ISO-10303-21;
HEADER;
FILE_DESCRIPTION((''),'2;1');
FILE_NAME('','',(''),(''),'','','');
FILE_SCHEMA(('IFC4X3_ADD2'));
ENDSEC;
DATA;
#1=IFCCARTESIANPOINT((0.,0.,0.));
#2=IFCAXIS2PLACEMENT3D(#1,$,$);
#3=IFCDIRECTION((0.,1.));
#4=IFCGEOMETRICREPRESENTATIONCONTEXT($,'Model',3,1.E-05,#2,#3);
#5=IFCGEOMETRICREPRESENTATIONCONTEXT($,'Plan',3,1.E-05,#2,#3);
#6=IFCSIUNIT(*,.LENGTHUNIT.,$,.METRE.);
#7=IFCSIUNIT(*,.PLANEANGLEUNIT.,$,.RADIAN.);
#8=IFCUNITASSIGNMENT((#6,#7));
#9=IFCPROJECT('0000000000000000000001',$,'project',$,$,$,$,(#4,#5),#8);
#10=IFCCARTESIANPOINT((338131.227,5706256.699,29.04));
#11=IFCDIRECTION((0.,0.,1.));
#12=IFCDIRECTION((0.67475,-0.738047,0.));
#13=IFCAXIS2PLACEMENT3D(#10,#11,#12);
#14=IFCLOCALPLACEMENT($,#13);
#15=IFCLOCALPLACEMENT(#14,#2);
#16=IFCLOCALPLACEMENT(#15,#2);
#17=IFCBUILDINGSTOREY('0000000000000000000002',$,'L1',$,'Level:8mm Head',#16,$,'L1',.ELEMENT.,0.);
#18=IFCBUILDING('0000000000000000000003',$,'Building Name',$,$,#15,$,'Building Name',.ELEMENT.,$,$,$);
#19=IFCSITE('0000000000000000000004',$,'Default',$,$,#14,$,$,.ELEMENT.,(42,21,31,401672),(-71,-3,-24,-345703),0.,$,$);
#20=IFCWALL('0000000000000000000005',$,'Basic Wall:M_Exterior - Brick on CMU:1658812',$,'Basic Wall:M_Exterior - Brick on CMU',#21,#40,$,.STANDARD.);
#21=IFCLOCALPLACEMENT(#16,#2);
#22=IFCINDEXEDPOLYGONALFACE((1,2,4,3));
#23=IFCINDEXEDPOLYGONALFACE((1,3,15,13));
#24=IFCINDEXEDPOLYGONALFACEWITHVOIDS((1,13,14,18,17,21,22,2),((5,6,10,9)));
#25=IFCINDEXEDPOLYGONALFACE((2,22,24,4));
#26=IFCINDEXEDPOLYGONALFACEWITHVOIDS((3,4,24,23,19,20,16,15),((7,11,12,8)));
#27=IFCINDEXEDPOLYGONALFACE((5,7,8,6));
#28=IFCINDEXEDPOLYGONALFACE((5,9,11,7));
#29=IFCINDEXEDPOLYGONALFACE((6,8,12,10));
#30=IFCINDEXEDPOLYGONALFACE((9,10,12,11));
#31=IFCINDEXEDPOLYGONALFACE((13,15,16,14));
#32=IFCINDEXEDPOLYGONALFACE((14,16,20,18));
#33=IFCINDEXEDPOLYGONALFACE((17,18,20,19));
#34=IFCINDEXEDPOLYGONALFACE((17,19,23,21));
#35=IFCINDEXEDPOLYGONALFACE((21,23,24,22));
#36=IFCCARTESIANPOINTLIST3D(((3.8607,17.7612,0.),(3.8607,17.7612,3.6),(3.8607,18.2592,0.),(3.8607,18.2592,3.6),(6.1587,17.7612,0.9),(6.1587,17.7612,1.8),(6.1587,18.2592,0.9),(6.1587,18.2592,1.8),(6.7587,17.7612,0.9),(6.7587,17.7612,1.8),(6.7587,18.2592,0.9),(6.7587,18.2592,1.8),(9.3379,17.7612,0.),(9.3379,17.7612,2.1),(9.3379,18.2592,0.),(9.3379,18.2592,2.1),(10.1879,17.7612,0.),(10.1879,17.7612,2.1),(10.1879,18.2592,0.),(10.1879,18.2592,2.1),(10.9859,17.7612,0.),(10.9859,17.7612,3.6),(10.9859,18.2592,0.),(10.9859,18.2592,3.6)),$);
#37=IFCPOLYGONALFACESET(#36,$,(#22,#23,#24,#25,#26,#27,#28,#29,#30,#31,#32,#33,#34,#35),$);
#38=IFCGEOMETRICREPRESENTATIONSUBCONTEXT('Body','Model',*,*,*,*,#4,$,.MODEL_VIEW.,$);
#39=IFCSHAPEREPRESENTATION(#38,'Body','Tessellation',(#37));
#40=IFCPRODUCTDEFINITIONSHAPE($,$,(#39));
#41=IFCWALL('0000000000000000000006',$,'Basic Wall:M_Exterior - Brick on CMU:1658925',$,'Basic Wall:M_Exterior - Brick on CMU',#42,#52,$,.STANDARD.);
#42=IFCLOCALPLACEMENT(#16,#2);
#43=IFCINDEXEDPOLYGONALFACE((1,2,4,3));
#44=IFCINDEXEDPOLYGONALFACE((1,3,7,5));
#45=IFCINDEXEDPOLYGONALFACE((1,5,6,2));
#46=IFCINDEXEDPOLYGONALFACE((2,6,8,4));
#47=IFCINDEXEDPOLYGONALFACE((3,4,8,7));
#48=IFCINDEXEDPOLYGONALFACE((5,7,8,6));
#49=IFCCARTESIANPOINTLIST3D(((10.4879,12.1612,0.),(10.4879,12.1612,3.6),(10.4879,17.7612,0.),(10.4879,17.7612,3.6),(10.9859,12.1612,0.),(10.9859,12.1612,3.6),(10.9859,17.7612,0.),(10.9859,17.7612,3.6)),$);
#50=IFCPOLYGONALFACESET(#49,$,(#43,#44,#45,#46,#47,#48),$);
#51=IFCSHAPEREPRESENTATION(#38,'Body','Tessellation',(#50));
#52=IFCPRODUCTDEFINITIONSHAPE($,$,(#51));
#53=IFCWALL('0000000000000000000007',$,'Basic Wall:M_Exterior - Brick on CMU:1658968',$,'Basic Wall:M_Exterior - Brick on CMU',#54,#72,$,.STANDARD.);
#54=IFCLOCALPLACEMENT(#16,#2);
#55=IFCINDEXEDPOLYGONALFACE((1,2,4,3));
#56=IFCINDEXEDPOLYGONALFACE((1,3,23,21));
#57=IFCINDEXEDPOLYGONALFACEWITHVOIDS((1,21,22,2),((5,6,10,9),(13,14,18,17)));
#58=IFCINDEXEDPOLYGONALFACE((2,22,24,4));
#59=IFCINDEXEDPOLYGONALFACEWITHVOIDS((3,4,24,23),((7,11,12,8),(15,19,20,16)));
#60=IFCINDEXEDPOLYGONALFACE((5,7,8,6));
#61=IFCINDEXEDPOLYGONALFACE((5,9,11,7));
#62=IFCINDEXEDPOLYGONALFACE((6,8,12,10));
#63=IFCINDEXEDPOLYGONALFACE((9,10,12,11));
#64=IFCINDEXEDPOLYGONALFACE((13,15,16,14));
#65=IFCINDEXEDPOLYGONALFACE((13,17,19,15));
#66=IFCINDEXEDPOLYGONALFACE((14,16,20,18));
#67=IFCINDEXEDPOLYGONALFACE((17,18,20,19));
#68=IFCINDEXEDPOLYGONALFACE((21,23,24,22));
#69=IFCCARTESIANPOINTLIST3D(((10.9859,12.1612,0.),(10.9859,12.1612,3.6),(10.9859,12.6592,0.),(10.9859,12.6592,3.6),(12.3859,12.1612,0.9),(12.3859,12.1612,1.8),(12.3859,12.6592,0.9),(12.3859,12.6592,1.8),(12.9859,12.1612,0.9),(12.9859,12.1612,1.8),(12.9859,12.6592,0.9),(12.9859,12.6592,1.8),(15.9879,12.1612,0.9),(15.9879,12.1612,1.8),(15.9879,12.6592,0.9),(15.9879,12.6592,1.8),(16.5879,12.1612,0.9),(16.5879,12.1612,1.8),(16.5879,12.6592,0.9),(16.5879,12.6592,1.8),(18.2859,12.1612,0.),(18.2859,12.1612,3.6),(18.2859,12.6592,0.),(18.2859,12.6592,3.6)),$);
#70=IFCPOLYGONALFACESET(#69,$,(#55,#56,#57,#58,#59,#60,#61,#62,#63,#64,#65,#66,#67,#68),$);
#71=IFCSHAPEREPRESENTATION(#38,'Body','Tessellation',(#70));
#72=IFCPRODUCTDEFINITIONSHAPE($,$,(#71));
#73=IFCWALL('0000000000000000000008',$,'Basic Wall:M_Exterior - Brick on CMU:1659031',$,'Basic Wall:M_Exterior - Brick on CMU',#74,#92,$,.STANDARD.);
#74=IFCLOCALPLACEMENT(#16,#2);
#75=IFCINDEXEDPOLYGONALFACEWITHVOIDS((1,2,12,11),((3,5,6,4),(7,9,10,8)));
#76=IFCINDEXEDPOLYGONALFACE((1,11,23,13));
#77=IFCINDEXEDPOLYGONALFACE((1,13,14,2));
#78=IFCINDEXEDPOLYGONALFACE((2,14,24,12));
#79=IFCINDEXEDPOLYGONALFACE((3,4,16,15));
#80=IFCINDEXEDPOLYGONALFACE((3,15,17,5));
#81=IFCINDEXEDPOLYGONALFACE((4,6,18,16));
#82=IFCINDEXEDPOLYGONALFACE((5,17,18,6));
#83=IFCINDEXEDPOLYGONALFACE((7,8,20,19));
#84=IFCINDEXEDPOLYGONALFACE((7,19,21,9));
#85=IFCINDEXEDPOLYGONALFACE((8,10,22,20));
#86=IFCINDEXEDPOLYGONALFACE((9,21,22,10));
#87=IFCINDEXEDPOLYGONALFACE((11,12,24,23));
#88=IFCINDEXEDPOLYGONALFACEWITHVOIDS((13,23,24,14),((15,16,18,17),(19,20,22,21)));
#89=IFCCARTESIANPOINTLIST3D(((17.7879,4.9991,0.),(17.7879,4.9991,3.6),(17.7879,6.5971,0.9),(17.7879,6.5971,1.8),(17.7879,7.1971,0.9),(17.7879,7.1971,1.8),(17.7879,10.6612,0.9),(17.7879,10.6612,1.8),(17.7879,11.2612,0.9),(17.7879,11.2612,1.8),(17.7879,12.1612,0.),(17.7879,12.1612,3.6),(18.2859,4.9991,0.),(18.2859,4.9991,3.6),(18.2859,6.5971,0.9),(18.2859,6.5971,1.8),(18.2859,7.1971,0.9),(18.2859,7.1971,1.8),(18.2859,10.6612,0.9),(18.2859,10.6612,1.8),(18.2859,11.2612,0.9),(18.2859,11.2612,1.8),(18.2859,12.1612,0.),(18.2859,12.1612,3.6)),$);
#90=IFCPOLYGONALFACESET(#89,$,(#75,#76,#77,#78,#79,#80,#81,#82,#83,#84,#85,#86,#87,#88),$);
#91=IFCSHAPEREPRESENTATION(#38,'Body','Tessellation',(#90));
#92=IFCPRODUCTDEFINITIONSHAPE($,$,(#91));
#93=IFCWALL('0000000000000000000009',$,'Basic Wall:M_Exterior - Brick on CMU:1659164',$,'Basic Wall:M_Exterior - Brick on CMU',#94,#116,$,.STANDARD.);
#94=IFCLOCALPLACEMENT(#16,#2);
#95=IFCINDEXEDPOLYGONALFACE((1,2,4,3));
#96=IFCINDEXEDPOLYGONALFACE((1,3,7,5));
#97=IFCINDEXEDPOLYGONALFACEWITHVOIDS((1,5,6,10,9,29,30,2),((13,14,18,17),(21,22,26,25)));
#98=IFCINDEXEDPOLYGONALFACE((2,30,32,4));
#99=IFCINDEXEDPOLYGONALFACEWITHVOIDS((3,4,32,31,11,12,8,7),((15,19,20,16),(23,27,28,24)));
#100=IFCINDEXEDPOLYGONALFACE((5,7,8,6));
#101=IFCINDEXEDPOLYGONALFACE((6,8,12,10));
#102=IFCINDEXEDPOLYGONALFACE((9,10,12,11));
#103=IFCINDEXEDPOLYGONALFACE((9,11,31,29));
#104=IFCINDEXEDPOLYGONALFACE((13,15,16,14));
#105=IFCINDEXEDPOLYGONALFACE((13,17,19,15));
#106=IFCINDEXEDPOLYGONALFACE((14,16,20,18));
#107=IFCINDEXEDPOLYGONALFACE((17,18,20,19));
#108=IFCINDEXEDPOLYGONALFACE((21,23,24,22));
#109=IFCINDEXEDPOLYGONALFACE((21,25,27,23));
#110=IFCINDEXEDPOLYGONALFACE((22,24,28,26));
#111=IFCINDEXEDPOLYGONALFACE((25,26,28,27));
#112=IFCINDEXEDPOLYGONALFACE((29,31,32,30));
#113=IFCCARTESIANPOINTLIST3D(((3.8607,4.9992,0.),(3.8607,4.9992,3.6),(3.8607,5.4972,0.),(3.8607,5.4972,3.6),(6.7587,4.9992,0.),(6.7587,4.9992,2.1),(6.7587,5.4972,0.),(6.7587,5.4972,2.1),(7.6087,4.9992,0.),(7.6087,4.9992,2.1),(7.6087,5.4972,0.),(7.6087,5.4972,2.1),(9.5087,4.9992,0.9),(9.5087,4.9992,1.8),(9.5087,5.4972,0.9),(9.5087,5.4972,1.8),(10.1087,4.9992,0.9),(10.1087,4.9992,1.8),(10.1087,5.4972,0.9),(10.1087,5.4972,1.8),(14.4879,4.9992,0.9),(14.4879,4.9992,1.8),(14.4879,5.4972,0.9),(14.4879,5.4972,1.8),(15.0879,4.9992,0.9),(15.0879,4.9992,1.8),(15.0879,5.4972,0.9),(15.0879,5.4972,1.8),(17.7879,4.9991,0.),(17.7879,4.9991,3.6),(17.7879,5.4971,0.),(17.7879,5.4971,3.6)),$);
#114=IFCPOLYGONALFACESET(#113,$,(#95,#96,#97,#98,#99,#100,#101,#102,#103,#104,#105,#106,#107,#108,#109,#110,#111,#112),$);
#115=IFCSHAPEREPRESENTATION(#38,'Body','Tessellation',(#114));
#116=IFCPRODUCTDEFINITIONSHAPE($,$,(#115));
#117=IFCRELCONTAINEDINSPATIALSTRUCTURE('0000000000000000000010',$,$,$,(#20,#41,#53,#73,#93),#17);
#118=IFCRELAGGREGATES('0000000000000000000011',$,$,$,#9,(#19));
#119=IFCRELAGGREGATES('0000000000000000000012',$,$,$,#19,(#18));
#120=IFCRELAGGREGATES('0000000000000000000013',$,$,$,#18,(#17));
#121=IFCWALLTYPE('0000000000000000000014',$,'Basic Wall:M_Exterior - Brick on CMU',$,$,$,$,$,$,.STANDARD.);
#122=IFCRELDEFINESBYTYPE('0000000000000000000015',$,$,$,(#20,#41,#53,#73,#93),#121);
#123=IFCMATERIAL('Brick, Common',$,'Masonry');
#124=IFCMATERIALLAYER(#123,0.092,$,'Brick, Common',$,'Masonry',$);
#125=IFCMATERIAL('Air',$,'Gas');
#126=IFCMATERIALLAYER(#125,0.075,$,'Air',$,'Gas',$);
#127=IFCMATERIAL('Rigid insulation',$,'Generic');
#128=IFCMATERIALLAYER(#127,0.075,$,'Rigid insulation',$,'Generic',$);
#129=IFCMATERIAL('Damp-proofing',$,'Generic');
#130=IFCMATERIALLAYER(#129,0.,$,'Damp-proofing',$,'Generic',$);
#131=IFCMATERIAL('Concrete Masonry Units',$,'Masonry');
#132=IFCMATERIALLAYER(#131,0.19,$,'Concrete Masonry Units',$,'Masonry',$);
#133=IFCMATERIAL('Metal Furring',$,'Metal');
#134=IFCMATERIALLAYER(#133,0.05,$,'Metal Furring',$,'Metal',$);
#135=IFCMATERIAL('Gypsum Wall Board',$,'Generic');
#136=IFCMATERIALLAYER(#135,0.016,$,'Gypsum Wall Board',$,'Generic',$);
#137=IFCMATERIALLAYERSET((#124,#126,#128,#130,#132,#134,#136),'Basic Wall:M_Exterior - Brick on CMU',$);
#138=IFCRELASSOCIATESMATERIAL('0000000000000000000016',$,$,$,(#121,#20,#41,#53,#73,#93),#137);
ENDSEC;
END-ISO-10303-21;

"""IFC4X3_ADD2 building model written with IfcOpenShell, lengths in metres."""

from ifc_helpers import new_model, si_unit, direction, frame, frame_2d, origin, origin_2d_with_axis, place, context, subcontext, project, spatial, rectangle, extrude, material, layer, layer_set, type_object, element, save


model = new_model("IFC4X3_ADD2")

# Units and contexts
model_context = context("Model", 3, precision=1e-05, world=origin(), true_north=direction((0.0, 1.0)))
plan_context = context("Plan", 3, precision=1e-05, world=origin(), true_north=direction((0.0, 1.0)))
body_context = subcontext(model_context, "Body", "Model", "MODEL_VIEW")
ifc_project = project(units=[si_unit("LENGTHUNIT", "METRE"), si_unit("PLANEANGLEUNIT", "RADIAN")], contexts=[model_context, plan_context])

# Site, building, storey
site_placement = place(None, frame((338131.227, 5706256.699, 29.04), z_axis=(0.0, 0.0, 1.0), x_axis=(0.67475, -0.738047, 0.0)))
site = spatial("IfcSite", under=ifc_project, at=site_placement, Name="Default", CompositionType="ELEMENT", RefLatitude=(42, 21, 31, 401672), RefLongitude=(-71, -3, -24, -345703), RefElevation=0.0)
building_placement = place(site_placement, origin())
building = spatial("IfcBuilding", under=site, at=building_placement, Name="Building Name", LongName="Building Name", CompositionType="ELEMENT")
storey_placement = place(building_placement, origin())
storey = spatial("IfcBuildingStorey", under=building, at=storey_placement, Name="L1", ObjectType="Level:8mm Head", LongName="L1", CompositionType="ELEMENT", Elevation=0.0)

# Wall, openings
ifc_material_1 = material(Name="Brick, Common", Category="Masonry")
ifc_layer_1 = layer(ifc_material_1, 0.092, Name="Brick, Common", Category="Masonry")
ifc_material_2 = material(Name="Air", Category="Gas")
ifc_layer_2 = layer(ifc_material_2, 0.075, Name="Air", Category="Gas")
ifc_material_3 = material(Name="Rigid insulation", Category="Generic")
ifc_layer_3 = layer(ifc_material_3, 0.075, Name="Rigid insulation", Category="Generic")
ifc_material_4 = material(Name="Damp-proofing", Category="Generic")
ifc_layer_4 = layer(ifc_material_4, 0.0, Name="Damp-proofing", Category="Generic")
ifc_material_5 = material(Name="Concrete Masonry Units", Category="Masonry")
ifc_layer_5 = layer(ifc_material_5, 0.19, Name="Concrete Masonry Units", Category="Masonry")
ifc_material_6 = material(Name="Metal Furring", Category="Metal")
ifc_layer_6 = layer(ifc_material_6, 0.05, Name="Metal Furring", Category="Metal")
ifc_material_7 = material(Name="Gypsum Wall Board", Category="Generic")
ifc_layer_7 = layer(ifc_material_7, 0.016, Name="Gypsum Wall Board", Category="Generic")
ifc_layer_set_1 = layer_set([ifc_layer_1, ifc_layer_2, ifc_layer_3, ifc_layer_4, ifc_layer_5, ifc_layer_6, ifc_layer_7], Name="Basic Wall:M_Exterior - Brick on CMU")
wall_type = type_object("IfcWallType", Name="Basic Wall:M_Exterior - Brick on CMU", PredefinedType="STANDARD", material=ifc_layer_set_1)
wall_1_placement = place(storey_placement, frame((3.8607, 18.0102, 0.0)))
wall_1 = element("IfcWall", 1, at=wall_1_placement, inside=storey, type_object=wall_type, material=ifc_layer_set_1, Name="Basic Wall:M_Exterior - Brick on CMU:1658812", ObjectType="Basic Wall:M_Exterior - Brick on CMU", PredefinedType="STANDARD", context=body_context, shape_type="SweptSolid", body=[
    extrude(rectangle(XDim=7.1251, YDim=0.498, at=frame_2d((3.5626, 0.0), x_axis=(-1.0, 0.0))), origin(), (0.0, 0.0, 1.0), 3.6),
])
opening_1_placement = place(wall_1_placement, frame((-3.8607, -18.0102, 0.0)))
element("IfcOpeningElement", 2, at=opening_1_placement, cuts=wall_1, PredefinedType="OPENING", context=body_context, shape_type="SweptSolid", body=[
    extrude(rectangle(XDim=2.1, YDim=0.85, at=frame_2d((0.0, 0.0), x_axis=(0.0, 1.0))), frame((9.7629, 16.2372, 1.05), z_axis=(0.0, 1.0, 0.0), x_axis=(-1.0, 0.0, 0.0)), (0.0, 0.0, 1.0), 3.048),
])
opening_2_placement = place(wall_1_placement, frame((-3.8607, -18.0102, 0.9)))
element("IfcOpeningElement", 3, at=opening_2_placement, cuts=wall_1, PredefinedType="OPENING", context=body_context, shape_type="SweptSolid", body=[
    extrude(rectangle(XDim=0.9, YDim=0.6, at=origin_2d_with_axis()), frame((6.4587, 16.2372, 0.45), z_axis=(0.0, 1.0, 0.0), x_axis=(0.0, 0.0, -1.0)), (0.0, 0.0, 1.0), 3.048),
])

# Wall
wall_2_placement = place(storey_placement, frame((10.7369, 17.7612, 0.0), z_axis=(0.0, 0.0, 1.0), x_axis=(0.0, -1.0, 0.0)))
element("IfcWall", 4, at=wall_2_placement, inside=storey, type_object=wall_type, material=ifc_layer_set_1, Name="Basic Wall:M_Exterior - Brick on CMU:1658925", ObjectType="Basic Wall:M_Exterior - Brick on CMU", PredefinedType="STANDARD", context=body_context, shape_type="SweptSolid", body=[
    extrude(rectangle(XDim=5.6, YDim=0.498, at=frame_2d((2.8, 0.0), x_axis=(-1.0, 0.0))), origin(), (0.0, 0.0, 1.0), 3.6),
])

# Walls, openings
wall_3_placement = place(storey_placement, frame((10.9859, 12.4102, 0.0)))
wall_3 = element("IfcWall", 5, at=wall_3_placement, inside=storey, type_object=wall_type, material=ifc_layer_set_1, Name="Basic Wall:M_Exterior - Brick on CMU:1658968", ObjectType="Basic Wall:M_Exterior - Brick on CMU", PredefinedType="STANDARD", context=body_context, shape_type="SweptSolid", body=[
    extrude(rectangle(XDim=7.3, YDim=0.498, at=frame_2d((3.65, 0.0), x_axis=(-1.0, 0.0))), origin(), (0.0, 0.0, 1.0), 3.6),
])
opening_3_placement = place(wall_3_placement, frame((-10.9859, -12.4102, 0.9)))
element("IfcOpeningElement", 6, at=opening_3_placement, cuts=wall_3, PredefinedType="OPENING", context=body_context, shape_type="SweptSolid", body=[
    extrude(rectangle(XDim=0.9, YDim=0.6, at=frame_2d((0.0, 0.0), x_axis=(1.0, 0.0))), frame((16.2879, 10.6372, 0.45), z_axis=(0.0, 1.0, 0.0), x_axis=(0.0, 0.0, -1.0)), (0.0, 0.0, 1.0), 3.048),
])
opening_4_placement = place(wall_3_placement, frame((-10.9859, -12.4102, 0.9)))
element("IfcOpeningElement", 7, at=opening_4_placement, cuts=wall_3, PredefinedType="OPENING", context=body_context, shape_type="SweptSolid", body=[
    extrude(rectangle(XDim=0.9, YDim=0.6, at=frame_2d((0.0, 0.0), x_axis=(1.0, 0.0))), frame((12.6859, 10.6372, 0.45), z_axis=(0.0, 1.0, 0.0), x_axis=(0.0, 0.0, -1.0)), (0.0, 0.0, 1.0), 3.048),
])
wall_4_placement = place(storey_placement, frame((18.0369, 12.1612, 0.0), z_axis=(0.0, 0.0, 1.0), x_axis=(0.0, -1.0, 0.0)))
wall_4 = element("IfcWall", 8, at=wall_4_placement, inside=storey, type_object=wall_type, material=ifc_layer_set_1, Name="Basic Wall:M_Exterior - Brick on CMU:1659031", ObjectType="Basic Wall:M_Exterior - Brick on CMU", PredefinedType="STANDARD", context=body_context, shape_type="SweptSolid", body=[
    extrude(rectangle(XDim=7.1621, YDim=0.498, at=frame_2d((3.581, 0.0), x_axis=(-1.0, 0.0))), origin(), (0.0, 0.0, 1.0), 3.6),
])
opening_5_placement = place(wall_4_placement, frame((12.1612, -18.0369, 0.9)))
element("IfcOpeningElement", 9, at=opening_5_placement, cuts=wall_4, PredefinedType="OPENING", context=body_context, shape_type="SweptSolid", body=[
    extrude(rectangle(XDim=0.9, YDim=0.6, at=frame_2d((0.0, 0.0), x_axis=(1.0, 0.0))), frame((-6.8971, 16.2639, 0.45), z_axis=(0.0, 1.0, 0.0), x_axis=(0.0, 0.0, -1.0)), (0.0, 0.0, 1.0), 3.048),
])
opening_6_placement = place(wall_4_placement, frame((12.1612, -18.0369, 0.9)))
element("IfcOpeningElement", 10, at=opening_6_placement, cuts=wall_4, PredefinedType="OPENING", context=body_context, shape_type="SweptSolid", body=[
    extrude(rectangle(XDim=0.9, YDim=0.6, at=frame_2d((0.0, 0.0), x_axis=(1.0, 0.0))), frame((-10.9612, 16.2639, 0.45), z_axis=(0.0, 1.0, 0.0), x_axis=(0.0, 0.0, -1.0)), (0.0, 0.0, 1.0), 3.048),
])
wall_5_placement = place(storey_placement, frame((17.7879, 5.2481, 0.0), z_axis=(0.0, 0.0, 1.0), x_axis=(-1.0, 0.000006, 0.0)))
wall_5 = element("IfcWall", 11, at=wall_5_placement, inside=storey, type_object=wall_type, material=ifc_layer_set_1, Name="Basic Wall:M_Exterior - Brick on CMU:1659164", ObjectType="Basic Wall:M_Exterior - Brick on CMU", PredefinedType="STANDARD", context=body_context, shape_type="SweptSolid", body=[
    extrude(rectangle(XDim=13.9271, YDim=0.498, at=frame_2d((6.9636, 0.0), x_axis=(-1.0, 0.0))), origin(), (0.0, 0.0, 1.0), 3.6),
])
opening_7_placement = place(wall_5_placement, frame((17.7878, 5.2482, 0.0)))
element("IfcOpeningElement", 12, at=opening_7_placement, cuts=wall_5, PredefinedType="OPENING", context=body_context, shape_type="SweptSolid", body=[
    extrude(rectangle(XDim=2.1, YDim=0.85, at=frame_2d((0.0, 0.0), x_axis=(0.0, 1.0))), frame((-7.1837, -7.0212, 1.05), z_axis=(0.0, 1.0, 0.0), x_axis=(-1.0, 0.0, 0.0)), (0.0, 0.0, 1.0), 3.048),
])
opening_8_placement = place(wall_5_placement, frame((17.7878, 5.2482, 0.9)))
element("IfcOpeningElement", 13, at=opening_8_placement, cuts=wall_5, PredefinedType="OPENING", context=body_context, shape_type="SweptSolid", body=[
    extrude(rectangle(XDim=0.9, YDim=0.6, at=frame_2d((0.0, 0.0), x_axis=(1.0, 0.0))), frame((-9.8087, -7.0212, 0.45), z_axis=(0.0, 1.0, 0.0), x_axis=(0.0, 0.0, -1.0)), (0.0, 0.0, 1.0), 3.048),
])
opening_9_placement = place(wall_5_placement, frame((17.7878, 5.2482, 0.9)))
element("IfcOpeningElement", 14, at=opening_9_placement, cuts=wall_5, PredefinedType="OPENING", context=body_context, shape_type="SweptSolid", body=[
    extrude(rectangle(XDim=0.9, YDim=0.6, at=frame_2d((0.0, 0.0), x_axis=(1.0, 0.0))), frame((-14.7878, -7.0212, 0.45), z_axis=(0.0, 1.0, 0.0), x_axis=(0.0, 0.0, -1.0)), (0.0, 0.0, 1.0), 3.048),
])

save(model, "model.ifc")
